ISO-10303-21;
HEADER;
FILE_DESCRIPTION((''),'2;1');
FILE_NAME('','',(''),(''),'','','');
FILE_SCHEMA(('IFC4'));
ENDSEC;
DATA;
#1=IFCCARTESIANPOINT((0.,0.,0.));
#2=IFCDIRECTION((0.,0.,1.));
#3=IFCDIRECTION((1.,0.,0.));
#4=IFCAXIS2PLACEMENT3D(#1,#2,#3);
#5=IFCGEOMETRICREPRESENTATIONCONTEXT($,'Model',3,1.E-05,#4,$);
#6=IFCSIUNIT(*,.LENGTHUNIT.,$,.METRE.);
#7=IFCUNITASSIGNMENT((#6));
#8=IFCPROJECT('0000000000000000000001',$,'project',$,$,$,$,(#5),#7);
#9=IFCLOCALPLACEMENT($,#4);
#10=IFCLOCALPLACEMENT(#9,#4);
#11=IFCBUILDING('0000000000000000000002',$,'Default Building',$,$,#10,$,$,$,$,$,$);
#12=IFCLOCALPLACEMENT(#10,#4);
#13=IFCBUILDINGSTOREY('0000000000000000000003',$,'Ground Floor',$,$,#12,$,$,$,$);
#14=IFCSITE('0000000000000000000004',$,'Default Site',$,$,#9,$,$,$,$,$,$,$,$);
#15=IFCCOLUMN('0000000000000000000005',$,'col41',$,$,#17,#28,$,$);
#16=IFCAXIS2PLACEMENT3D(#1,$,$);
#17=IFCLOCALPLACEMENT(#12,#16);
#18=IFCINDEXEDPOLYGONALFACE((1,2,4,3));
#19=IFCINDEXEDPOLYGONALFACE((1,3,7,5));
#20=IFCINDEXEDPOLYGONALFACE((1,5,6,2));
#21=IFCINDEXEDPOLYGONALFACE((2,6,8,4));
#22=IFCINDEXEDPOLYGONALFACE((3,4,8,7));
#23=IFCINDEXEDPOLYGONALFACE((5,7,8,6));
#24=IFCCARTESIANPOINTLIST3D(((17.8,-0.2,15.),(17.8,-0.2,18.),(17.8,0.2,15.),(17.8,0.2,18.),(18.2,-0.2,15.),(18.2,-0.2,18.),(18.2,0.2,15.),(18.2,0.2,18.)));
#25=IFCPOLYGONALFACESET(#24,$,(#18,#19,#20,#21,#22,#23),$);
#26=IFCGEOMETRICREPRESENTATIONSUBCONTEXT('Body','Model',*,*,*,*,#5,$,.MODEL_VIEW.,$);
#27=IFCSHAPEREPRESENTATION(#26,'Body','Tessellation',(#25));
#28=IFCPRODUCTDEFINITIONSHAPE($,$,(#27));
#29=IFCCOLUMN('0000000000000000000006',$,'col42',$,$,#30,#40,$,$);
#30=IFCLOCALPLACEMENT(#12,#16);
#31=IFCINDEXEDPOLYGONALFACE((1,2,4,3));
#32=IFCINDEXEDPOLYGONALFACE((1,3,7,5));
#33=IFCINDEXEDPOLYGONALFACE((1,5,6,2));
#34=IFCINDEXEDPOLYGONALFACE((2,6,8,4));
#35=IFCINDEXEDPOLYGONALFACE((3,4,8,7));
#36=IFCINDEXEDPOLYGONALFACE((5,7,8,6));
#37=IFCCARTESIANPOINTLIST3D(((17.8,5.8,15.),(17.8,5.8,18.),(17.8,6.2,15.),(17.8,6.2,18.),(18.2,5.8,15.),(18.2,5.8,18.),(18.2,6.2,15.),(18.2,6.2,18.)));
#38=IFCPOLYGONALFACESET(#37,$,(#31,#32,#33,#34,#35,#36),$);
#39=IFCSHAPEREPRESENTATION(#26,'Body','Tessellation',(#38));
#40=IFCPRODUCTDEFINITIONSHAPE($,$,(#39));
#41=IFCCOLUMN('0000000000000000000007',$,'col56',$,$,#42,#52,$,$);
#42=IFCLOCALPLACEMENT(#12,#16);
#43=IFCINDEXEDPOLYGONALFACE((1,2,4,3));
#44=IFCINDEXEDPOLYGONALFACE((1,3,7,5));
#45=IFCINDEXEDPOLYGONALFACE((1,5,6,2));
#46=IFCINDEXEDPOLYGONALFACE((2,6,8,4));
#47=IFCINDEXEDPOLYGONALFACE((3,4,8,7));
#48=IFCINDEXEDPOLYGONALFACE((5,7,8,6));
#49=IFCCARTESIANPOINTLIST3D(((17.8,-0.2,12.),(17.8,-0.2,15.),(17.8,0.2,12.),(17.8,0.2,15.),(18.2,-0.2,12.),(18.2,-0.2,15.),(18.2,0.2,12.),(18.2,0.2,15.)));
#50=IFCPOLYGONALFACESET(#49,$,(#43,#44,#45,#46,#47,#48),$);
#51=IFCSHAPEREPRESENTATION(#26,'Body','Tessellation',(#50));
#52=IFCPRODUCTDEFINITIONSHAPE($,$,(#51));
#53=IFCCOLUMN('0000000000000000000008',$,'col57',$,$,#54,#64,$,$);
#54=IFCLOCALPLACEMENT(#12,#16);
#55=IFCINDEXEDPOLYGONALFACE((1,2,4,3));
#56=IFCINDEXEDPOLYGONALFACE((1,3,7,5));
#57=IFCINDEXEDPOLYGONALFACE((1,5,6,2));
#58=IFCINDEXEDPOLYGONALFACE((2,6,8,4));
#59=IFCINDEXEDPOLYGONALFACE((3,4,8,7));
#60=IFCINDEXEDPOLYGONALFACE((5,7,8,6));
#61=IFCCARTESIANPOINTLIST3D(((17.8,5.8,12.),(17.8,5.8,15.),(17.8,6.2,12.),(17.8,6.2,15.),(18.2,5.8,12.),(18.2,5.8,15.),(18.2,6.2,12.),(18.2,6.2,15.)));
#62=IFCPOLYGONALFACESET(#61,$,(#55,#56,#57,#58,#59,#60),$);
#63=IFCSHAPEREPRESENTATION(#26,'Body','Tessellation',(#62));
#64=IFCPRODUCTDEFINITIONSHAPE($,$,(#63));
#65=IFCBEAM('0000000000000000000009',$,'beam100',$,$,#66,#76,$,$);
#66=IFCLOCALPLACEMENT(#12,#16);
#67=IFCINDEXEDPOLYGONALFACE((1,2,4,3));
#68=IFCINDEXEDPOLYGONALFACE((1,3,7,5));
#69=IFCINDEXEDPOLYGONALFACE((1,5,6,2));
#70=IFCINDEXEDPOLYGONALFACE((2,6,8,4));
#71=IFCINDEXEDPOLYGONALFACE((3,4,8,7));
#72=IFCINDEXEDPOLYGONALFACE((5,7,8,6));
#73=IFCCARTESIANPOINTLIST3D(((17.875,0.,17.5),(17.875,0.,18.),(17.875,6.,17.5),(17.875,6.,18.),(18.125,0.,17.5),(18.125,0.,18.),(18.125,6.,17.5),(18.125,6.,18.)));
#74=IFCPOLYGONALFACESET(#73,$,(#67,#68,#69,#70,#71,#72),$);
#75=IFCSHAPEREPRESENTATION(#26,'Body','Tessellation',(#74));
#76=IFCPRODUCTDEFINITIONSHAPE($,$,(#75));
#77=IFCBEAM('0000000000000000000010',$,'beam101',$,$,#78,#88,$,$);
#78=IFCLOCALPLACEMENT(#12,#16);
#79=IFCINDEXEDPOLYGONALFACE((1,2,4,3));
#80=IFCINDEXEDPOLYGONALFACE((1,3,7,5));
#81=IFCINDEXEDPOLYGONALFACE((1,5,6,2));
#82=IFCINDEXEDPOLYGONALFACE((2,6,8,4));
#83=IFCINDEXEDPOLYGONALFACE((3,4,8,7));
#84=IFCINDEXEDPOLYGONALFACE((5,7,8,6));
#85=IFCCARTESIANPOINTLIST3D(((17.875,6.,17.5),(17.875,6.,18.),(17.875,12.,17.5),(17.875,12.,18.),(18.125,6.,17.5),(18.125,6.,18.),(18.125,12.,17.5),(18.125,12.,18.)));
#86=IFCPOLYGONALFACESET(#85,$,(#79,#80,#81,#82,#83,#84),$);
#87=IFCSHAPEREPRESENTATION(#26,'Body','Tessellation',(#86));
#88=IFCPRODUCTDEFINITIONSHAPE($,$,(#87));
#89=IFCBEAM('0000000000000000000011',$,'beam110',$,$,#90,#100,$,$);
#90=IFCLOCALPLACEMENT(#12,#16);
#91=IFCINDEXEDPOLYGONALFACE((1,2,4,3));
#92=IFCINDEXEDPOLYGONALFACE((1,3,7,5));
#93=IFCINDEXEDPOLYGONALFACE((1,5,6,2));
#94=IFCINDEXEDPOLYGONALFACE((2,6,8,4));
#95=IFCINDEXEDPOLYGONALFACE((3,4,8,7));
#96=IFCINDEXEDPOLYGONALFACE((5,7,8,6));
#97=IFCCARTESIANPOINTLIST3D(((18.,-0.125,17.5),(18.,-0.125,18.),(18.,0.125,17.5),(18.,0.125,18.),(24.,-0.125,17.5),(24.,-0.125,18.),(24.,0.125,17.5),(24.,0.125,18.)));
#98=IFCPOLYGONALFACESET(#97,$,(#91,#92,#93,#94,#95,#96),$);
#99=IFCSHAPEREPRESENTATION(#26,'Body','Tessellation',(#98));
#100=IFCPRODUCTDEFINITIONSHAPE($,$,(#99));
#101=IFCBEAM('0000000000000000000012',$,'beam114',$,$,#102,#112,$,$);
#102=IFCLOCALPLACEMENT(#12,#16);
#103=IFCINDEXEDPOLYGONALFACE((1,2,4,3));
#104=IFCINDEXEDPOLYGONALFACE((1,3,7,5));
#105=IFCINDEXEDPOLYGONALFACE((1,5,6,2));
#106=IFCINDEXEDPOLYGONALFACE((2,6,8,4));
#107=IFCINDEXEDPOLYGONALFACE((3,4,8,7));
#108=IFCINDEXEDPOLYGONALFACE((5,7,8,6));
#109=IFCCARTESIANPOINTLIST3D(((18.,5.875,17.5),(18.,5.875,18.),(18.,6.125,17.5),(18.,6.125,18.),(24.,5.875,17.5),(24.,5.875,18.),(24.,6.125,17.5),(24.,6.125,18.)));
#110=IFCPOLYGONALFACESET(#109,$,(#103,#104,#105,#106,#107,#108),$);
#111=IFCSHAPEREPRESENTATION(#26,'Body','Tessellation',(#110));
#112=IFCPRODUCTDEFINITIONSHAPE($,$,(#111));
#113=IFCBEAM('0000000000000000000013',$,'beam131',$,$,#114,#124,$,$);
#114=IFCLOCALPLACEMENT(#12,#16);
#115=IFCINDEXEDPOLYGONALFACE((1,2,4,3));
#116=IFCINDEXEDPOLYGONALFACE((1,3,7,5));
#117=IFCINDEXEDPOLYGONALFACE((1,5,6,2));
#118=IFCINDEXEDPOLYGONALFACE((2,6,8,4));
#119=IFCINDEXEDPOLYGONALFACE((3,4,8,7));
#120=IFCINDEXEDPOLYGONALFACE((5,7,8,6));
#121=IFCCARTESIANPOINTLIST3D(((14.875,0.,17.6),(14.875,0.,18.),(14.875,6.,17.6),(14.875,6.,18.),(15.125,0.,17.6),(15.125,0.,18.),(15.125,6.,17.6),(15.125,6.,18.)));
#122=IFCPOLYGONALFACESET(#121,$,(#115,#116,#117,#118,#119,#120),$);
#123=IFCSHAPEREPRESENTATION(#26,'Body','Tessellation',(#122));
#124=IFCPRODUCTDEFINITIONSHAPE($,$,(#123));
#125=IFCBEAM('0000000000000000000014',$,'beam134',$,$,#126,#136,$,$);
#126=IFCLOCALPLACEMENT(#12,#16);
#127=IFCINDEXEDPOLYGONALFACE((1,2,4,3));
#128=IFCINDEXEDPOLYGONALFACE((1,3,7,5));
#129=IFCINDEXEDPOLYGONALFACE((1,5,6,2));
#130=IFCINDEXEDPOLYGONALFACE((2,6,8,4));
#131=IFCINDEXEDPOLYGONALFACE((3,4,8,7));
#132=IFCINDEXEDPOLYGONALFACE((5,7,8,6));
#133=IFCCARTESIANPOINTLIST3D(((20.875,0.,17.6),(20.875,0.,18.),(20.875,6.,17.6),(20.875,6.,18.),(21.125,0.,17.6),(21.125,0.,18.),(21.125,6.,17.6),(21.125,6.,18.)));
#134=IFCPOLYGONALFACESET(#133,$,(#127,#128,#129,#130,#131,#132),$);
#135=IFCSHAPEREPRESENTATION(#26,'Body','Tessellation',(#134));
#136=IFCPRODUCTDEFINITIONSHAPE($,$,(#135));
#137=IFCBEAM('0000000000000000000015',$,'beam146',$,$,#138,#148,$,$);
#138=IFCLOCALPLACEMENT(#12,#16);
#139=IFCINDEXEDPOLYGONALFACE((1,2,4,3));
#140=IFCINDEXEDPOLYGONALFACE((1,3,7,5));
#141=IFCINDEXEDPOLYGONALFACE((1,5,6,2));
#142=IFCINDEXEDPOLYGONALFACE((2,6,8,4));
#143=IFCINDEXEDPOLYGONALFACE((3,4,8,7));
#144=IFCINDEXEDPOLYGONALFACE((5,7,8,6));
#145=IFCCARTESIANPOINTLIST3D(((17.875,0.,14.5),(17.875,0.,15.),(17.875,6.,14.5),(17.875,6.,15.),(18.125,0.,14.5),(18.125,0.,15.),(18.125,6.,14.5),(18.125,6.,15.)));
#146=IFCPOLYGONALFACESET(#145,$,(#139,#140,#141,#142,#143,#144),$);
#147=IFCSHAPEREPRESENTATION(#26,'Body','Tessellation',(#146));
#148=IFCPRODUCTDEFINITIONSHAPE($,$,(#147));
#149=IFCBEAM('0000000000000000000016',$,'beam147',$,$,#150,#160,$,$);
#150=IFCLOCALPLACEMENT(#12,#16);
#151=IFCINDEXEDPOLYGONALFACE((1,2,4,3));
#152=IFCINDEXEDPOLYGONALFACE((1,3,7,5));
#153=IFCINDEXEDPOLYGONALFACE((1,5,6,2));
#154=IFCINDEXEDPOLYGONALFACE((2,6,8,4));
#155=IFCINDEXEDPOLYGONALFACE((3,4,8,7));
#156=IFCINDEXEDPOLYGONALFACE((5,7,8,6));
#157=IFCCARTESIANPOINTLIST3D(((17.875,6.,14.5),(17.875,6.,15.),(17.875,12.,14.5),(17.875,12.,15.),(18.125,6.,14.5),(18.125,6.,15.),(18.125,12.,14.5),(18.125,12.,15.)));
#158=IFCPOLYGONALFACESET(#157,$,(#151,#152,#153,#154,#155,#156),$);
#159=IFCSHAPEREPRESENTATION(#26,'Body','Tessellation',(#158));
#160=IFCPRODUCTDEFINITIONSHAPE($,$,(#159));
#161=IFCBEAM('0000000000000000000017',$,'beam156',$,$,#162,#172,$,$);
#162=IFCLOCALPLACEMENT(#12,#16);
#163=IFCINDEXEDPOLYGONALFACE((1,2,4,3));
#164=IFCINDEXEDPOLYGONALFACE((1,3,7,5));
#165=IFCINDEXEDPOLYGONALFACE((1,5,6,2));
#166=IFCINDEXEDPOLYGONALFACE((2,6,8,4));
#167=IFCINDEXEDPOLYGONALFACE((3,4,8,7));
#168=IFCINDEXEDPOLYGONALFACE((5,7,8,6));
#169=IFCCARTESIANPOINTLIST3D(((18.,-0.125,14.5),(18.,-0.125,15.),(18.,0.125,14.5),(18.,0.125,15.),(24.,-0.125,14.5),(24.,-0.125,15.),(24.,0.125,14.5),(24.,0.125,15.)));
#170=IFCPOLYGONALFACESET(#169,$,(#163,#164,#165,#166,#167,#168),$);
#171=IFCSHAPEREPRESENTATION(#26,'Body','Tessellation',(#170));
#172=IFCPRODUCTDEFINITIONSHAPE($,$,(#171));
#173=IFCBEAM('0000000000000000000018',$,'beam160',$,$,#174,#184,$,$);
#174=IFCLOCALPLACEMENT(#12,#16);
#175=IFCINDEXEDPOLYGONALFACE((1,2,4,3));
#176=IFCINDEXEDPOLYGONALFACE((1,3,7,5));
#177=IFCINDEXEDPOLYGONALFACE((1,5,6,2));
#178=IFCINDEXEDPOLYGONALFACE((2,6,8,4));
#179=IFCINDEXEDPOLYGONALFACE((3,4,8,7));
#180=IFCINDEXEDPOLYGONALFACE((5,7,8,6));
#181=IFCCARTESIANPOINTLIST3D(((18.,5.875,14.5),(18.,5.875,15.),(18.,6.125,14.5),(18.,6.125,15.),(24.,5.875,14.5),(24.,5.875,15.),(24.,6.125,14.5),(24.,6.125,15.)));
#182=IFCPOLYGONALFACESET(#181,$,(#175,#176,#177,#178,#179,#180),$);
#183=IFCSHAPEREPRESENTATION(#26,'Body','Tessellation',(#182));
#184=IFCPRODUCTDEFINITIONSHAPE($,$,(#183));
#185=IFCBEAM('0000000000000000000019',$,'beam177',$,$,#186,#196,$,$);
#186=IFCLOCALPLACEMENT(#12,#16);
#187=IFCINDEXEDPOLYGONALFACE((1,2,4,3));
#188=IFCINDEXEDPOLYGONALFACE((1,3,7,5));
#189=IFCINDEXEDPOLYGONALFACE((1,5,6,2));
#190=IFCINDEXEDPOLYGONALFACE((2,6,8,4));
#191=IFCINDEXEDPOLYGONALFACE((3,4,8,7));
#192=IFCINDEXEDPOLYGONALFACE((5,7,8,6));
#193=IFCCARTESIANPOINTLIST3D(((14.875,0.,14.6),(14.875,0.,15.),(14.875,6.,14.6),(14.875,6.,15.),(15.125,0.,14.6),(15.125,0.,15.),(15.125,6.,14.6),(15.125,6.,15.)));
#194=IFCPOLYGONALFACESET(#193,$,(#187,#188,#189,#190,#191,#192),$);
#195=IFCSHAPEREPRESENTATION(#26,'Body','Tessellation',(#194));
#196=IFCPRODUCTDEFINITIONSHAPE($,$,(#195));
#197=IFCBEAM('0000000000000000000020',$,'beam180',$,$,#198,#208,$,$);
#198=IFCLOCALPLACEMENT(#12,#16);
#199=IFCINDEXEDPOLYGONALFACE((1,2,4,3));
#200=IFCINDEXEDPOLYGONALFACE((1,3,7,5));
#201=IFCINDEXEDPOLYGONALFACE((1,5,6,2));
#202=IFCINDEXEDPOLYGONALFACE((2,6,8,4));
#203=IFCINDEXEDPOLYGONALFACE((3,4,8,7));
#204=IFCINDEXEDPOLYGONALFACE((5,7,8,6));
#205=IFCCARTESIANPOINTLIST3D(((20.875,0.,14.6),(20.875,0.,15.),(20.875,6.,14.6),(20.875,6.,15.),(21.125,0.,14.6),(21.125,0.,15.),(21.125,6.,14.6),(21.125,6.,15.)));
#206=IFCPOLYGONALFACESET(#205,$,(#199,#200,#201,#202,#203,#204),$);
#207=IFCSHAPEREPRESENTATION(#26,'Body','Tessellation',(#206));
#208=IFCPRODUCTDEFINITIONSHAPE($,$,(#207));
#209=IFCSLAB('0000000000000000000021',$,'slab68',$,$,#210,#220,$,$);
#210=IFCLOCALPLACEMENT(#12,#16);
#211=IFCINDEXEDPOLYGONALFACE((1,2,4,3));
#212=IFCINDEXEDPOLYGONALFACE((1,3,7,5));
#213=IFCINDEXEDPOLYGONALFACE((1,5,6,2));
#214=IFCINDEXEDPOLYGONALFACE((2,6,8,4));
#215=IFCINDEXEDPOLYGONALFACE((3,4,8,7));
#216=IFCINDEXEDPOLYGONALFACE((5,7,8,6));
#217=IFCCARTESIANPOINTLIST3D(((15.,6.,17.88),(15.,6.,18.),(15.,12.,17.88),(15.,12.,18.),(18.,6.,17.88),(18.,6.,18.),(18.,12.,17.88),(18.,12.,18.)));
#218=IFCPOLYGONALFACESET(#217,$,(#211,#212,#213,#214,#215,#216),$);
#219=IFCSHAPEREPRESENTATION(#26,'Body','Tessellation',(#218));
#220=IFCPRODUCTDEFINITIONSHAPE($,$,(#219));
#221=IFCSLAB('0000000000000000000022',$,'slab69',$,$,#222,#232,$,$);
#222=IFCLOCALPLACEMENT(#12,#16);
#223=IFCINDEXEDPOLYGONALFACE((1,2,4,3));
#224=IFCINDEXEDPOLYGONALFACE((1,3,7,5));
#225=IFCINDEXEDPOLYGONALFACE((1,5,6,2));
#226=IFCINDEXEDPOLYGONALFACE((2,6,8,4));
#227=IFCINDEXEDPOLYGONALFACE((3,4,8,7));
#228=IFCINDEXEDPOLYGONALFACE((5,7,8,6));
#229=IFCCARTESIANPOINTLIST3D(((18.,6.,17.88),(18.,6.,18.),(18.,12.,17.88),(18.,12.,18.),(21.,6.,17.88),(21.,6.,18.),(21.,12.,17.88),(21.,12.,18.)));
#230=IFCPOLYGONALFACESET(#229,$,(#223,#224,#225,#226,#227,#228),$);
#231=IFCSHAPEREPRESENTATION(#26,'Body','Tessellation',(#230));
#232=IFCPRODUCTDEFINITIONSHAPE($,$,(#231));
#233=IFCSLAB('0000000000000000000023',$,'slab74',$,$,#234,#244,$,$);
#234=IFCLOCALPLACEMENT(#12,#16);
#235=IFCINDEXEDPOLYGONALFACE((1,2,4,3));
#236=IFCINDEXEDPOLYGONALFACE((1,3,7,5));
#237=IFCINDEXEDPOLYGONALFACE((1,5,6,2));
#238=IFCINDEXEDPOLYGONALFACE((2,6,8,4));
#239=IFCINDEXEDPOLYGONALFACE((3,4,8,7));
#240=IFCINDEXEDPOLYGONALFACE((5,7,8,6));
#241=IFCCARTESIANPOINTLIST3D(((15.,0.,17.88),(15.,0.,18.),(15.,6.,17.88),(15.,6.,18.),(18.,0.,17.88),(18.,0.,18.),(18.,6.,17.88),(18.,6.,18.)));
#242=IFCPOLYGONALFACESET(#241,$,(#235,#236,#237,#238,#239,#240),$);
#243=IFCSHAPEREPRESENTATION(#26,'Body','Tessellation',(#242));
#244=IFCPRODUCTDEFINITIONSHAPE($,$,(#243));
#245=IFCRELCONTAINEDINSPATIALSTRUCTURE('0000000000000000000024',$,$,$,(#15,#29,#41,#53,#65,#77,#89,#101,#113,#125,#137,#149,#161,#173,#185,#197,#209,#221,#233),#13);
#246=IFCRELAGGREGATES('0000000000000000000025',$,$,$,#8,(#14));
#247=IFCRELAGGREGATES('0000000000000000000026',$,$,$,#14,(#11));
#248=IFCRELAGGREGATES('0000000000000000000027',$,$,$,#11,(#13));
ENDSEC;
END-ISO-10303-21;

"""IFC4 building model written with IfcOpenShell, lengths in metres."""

from ifc_helpers import new_model, si_unit, frame, origin_with_axes, place, context, subcontext, project, spatial, indexed_curve, outline, extrude, element, save


model = new_model("IFC4")

# Units and contexts
model_context = context("Model", 3, precision=1e-05, world=origin_with_axes())
body_context = subcontext(model_context, "Body", "Model", "MODEL_VIEW")
ifc_project = project(units=[si_unit("LENGTHUNIT", "METRE")], contexts=[model_context])

# Site, building, storey
site_placement = place(None, origin_with_axes())
site = spatial("IfcSite", under=ifc_project, at=site_placement, Name="Default Site")
building_placement = place(site_placement, origin_with_axes())
building = spatial("IfcBuilding", under=site, at=building_placement, Name="Default Building")
storey_placement = place(building_placement, origin_with_axes())
storey = spatial("IfcBuildingStorey", under=building, at=storey_placement, Name="Ground Floor")

# Columns
for number, where, z_axis, x_axis, name in (
    (1, (17.8, -0.2, 15.0), (0.0, 0.0, 1.0), (1.0, 0.0, 0.0), "col41"),
    (2, (17.8, 5.8, 15.0), (0.0, 0.0, 1.0), (1.0, 0.0, 0.0), "col42"),
    (3, (17.8, -0.2, 12.0), (0.0, 0.0, 1.0), (1.0, 0.0, 0.0), "col56"),
    (4, (17.8, 5.8, 12.0), (0.0, 0.0, 1.0), (1.0, 0.0, 0.0), "col57"),
):
    element("IfcColumn", number, at=place(storey_placement, frame(where, z_axis=z_axis, x_axis=x_axis)), inside=storey, Name=name, context=body_context, shape_type="SweptSolid", body=[
        extrude(outline(indexed_curve([(0.0, 0.0), (0.0, 0.4), (0.4, 0.4), (0.4, 0.0), (0.0, 0.0)], self_intersect=False)), origin_with_axes(), (0.0, 0.0, 1.0), 3.0),
    ])

# Beams
for number, where, z_axis, x_axis, name in (
    (5, (18.125, 0.0, 17.5), (0.0, 0.0, 1.0), (0.0, 1.0, 0.0), "beam100"),
    (6, (18.125, 6.0, 17.5), (0.0, 0.0, 1.0), (0.0, 1.0, 0.0), "beam101"),
    (7, (18.0, -0.125, 17.5), (0.0, 0.0, 1.0), (1.0, 0.0, 0.0), "beam110"),
    (8, (18.0, 5.875, 17.5), (0.0, 0.0, 1.0), (1.0, 0.0, 0.0), "beam114"),
):
    element("IfcBeam", number, at=place(storey_placement, frame(where, z_axis=z_axis, x_axis=x_axis)), inside=storey, Name=name, context=body_context, shape_type="SweptSolid", body=[
        extrude(outline(indexed_curve([(0.0, 0.0), (0.0, 0.25), (6.0, 0.25), (6.0, 0.0), (0.0, 0.0)], self_intersect=False)), origin_with_axes(), (0.0, 0.0, 1.0), 0.5),
    ])
for number, where, z_axis, x_axis, name in (
    (9, (14.875, 6.0, 17.6), (0.0, 0.0, 1.0), (0.0, -1.0, 0.0), "beam131"),
    (10, (20.875, 6.0, 17.6), (0.0, 0.0, 1.0), (0.0, -1.0, 0.0), "beam134"),
):
    element("IfcBeam", number, at=place(storey_placement, frame(where, z_axis=z_axis, x_axis=x_axis)), inside=storey, Name=name, context=body_context, shape_type="SweptSolid", body=[
        extrude(outline(indexed_curve([(0.0, 0.0), (0.0, 0.25), (6.0, 0.25), (6.0, 0.0), (0.0, 0.0)], self_intersect=False)), origin_with_axes(), (0.0, 0.0, 1.0), 0.4),
    ])
for number, where, z_axis, x_axis, name in (
    (11, (18.125, 0.0, 14.5), (0.0, 0.0, 1.0), (0.0, 1.0, 0.0), "beam146"),
    (12, (18.125, 6.0, 14.5), (0.0, 0.0, 1.0), (0.0, 1.0, 0.0), "beam147"),
    (13, (18.0, -0.125, 14.5), (0.0, 0.0, 1.0), (1.0, 0.0, 0.0), "beam156"),
    (14, (18.0, 5.875, 14.5), (0.0, 0.0, 1.0), (1.0, 0.0, 0.0), "beam160"),
):
    element("IfcBeam", number, at=place(storey_placement, frame(where, z_axis=z_axis, x_axis=x_axis)), inside=storey, Name=name, context=body_context, shape_type="SweptSolid", body=[
        extrude(outline(indexed_curve([(0.0, 0.0), (0.0, 0.25), (6.0, 0.25), (6.0, 0.0), (0.0, 0.0)], self_intersect=False)), origin_with_axes(), (0.0, 0.0, 1.0), 0.5),
    ])
for number, where, z_axis, x_axis, name in (
    (15, (14.875, 6.0, 14.6), (0.0, 0.0, 1.0), (0.0, -1.0, 0.0), "beam177"),
    (16, (20.875, 6.0, 14.6), (0.0, 0.0, 1.0), (0.0, -1.0, 0.0), "beam180"),
):
    element("IfcBeam", number, at=place(storey_placement, frame(where, z_axis=z_axis, x_axis=x_axis)), inside=storey, Name=name, context=body_context, shape_type="SweptSolid", body=[
        extrude(outline(indexed_curve([(0.0, 0.0), (0.0, 0.25), (6.0, 0.25), (6.0, 0.0), (0.0, 0.0)], self_intersect=False)), origin_with_axes(), (0.0, 0.0, 1.0), 0.4),
    ])

# Slabs
for number, where, z_axis, x_axis, name in (
    (17, (15.0, 6.0, 17.88), (0.0, 0.0, 1.0), (1.0, 0.0, 0.0), "slab68"),
    (18, (18.0, 6.0, 17.88), (0.0, 0.0, 1.0), (1.0, 0.0, 0.0), "slab69"),
    (19, (15.0, 0.0, 17.88), (0.0, 0.0, 1.0), (1.0, 0.0, 0.0), "slab74"),
):
    element("IfcSlab", number, at=place(storey_placement, frame(where, z_axis=z_axis, x_axis=x_axis)), inside=storey, Name=name, context=body_context, shape_type="SweptSolid", body=[
        extrude(outline(indexed_curve([(0.0, 0.0), (0.0, 6.0), (3.0, 6.0), (3.0, 0.0), (0.0, 0.0)], self_intersect=False)), origin_with_axes(), (0.0, 0.0, 1.0), 0.12),
    ])

save(model, "model.ifc")
